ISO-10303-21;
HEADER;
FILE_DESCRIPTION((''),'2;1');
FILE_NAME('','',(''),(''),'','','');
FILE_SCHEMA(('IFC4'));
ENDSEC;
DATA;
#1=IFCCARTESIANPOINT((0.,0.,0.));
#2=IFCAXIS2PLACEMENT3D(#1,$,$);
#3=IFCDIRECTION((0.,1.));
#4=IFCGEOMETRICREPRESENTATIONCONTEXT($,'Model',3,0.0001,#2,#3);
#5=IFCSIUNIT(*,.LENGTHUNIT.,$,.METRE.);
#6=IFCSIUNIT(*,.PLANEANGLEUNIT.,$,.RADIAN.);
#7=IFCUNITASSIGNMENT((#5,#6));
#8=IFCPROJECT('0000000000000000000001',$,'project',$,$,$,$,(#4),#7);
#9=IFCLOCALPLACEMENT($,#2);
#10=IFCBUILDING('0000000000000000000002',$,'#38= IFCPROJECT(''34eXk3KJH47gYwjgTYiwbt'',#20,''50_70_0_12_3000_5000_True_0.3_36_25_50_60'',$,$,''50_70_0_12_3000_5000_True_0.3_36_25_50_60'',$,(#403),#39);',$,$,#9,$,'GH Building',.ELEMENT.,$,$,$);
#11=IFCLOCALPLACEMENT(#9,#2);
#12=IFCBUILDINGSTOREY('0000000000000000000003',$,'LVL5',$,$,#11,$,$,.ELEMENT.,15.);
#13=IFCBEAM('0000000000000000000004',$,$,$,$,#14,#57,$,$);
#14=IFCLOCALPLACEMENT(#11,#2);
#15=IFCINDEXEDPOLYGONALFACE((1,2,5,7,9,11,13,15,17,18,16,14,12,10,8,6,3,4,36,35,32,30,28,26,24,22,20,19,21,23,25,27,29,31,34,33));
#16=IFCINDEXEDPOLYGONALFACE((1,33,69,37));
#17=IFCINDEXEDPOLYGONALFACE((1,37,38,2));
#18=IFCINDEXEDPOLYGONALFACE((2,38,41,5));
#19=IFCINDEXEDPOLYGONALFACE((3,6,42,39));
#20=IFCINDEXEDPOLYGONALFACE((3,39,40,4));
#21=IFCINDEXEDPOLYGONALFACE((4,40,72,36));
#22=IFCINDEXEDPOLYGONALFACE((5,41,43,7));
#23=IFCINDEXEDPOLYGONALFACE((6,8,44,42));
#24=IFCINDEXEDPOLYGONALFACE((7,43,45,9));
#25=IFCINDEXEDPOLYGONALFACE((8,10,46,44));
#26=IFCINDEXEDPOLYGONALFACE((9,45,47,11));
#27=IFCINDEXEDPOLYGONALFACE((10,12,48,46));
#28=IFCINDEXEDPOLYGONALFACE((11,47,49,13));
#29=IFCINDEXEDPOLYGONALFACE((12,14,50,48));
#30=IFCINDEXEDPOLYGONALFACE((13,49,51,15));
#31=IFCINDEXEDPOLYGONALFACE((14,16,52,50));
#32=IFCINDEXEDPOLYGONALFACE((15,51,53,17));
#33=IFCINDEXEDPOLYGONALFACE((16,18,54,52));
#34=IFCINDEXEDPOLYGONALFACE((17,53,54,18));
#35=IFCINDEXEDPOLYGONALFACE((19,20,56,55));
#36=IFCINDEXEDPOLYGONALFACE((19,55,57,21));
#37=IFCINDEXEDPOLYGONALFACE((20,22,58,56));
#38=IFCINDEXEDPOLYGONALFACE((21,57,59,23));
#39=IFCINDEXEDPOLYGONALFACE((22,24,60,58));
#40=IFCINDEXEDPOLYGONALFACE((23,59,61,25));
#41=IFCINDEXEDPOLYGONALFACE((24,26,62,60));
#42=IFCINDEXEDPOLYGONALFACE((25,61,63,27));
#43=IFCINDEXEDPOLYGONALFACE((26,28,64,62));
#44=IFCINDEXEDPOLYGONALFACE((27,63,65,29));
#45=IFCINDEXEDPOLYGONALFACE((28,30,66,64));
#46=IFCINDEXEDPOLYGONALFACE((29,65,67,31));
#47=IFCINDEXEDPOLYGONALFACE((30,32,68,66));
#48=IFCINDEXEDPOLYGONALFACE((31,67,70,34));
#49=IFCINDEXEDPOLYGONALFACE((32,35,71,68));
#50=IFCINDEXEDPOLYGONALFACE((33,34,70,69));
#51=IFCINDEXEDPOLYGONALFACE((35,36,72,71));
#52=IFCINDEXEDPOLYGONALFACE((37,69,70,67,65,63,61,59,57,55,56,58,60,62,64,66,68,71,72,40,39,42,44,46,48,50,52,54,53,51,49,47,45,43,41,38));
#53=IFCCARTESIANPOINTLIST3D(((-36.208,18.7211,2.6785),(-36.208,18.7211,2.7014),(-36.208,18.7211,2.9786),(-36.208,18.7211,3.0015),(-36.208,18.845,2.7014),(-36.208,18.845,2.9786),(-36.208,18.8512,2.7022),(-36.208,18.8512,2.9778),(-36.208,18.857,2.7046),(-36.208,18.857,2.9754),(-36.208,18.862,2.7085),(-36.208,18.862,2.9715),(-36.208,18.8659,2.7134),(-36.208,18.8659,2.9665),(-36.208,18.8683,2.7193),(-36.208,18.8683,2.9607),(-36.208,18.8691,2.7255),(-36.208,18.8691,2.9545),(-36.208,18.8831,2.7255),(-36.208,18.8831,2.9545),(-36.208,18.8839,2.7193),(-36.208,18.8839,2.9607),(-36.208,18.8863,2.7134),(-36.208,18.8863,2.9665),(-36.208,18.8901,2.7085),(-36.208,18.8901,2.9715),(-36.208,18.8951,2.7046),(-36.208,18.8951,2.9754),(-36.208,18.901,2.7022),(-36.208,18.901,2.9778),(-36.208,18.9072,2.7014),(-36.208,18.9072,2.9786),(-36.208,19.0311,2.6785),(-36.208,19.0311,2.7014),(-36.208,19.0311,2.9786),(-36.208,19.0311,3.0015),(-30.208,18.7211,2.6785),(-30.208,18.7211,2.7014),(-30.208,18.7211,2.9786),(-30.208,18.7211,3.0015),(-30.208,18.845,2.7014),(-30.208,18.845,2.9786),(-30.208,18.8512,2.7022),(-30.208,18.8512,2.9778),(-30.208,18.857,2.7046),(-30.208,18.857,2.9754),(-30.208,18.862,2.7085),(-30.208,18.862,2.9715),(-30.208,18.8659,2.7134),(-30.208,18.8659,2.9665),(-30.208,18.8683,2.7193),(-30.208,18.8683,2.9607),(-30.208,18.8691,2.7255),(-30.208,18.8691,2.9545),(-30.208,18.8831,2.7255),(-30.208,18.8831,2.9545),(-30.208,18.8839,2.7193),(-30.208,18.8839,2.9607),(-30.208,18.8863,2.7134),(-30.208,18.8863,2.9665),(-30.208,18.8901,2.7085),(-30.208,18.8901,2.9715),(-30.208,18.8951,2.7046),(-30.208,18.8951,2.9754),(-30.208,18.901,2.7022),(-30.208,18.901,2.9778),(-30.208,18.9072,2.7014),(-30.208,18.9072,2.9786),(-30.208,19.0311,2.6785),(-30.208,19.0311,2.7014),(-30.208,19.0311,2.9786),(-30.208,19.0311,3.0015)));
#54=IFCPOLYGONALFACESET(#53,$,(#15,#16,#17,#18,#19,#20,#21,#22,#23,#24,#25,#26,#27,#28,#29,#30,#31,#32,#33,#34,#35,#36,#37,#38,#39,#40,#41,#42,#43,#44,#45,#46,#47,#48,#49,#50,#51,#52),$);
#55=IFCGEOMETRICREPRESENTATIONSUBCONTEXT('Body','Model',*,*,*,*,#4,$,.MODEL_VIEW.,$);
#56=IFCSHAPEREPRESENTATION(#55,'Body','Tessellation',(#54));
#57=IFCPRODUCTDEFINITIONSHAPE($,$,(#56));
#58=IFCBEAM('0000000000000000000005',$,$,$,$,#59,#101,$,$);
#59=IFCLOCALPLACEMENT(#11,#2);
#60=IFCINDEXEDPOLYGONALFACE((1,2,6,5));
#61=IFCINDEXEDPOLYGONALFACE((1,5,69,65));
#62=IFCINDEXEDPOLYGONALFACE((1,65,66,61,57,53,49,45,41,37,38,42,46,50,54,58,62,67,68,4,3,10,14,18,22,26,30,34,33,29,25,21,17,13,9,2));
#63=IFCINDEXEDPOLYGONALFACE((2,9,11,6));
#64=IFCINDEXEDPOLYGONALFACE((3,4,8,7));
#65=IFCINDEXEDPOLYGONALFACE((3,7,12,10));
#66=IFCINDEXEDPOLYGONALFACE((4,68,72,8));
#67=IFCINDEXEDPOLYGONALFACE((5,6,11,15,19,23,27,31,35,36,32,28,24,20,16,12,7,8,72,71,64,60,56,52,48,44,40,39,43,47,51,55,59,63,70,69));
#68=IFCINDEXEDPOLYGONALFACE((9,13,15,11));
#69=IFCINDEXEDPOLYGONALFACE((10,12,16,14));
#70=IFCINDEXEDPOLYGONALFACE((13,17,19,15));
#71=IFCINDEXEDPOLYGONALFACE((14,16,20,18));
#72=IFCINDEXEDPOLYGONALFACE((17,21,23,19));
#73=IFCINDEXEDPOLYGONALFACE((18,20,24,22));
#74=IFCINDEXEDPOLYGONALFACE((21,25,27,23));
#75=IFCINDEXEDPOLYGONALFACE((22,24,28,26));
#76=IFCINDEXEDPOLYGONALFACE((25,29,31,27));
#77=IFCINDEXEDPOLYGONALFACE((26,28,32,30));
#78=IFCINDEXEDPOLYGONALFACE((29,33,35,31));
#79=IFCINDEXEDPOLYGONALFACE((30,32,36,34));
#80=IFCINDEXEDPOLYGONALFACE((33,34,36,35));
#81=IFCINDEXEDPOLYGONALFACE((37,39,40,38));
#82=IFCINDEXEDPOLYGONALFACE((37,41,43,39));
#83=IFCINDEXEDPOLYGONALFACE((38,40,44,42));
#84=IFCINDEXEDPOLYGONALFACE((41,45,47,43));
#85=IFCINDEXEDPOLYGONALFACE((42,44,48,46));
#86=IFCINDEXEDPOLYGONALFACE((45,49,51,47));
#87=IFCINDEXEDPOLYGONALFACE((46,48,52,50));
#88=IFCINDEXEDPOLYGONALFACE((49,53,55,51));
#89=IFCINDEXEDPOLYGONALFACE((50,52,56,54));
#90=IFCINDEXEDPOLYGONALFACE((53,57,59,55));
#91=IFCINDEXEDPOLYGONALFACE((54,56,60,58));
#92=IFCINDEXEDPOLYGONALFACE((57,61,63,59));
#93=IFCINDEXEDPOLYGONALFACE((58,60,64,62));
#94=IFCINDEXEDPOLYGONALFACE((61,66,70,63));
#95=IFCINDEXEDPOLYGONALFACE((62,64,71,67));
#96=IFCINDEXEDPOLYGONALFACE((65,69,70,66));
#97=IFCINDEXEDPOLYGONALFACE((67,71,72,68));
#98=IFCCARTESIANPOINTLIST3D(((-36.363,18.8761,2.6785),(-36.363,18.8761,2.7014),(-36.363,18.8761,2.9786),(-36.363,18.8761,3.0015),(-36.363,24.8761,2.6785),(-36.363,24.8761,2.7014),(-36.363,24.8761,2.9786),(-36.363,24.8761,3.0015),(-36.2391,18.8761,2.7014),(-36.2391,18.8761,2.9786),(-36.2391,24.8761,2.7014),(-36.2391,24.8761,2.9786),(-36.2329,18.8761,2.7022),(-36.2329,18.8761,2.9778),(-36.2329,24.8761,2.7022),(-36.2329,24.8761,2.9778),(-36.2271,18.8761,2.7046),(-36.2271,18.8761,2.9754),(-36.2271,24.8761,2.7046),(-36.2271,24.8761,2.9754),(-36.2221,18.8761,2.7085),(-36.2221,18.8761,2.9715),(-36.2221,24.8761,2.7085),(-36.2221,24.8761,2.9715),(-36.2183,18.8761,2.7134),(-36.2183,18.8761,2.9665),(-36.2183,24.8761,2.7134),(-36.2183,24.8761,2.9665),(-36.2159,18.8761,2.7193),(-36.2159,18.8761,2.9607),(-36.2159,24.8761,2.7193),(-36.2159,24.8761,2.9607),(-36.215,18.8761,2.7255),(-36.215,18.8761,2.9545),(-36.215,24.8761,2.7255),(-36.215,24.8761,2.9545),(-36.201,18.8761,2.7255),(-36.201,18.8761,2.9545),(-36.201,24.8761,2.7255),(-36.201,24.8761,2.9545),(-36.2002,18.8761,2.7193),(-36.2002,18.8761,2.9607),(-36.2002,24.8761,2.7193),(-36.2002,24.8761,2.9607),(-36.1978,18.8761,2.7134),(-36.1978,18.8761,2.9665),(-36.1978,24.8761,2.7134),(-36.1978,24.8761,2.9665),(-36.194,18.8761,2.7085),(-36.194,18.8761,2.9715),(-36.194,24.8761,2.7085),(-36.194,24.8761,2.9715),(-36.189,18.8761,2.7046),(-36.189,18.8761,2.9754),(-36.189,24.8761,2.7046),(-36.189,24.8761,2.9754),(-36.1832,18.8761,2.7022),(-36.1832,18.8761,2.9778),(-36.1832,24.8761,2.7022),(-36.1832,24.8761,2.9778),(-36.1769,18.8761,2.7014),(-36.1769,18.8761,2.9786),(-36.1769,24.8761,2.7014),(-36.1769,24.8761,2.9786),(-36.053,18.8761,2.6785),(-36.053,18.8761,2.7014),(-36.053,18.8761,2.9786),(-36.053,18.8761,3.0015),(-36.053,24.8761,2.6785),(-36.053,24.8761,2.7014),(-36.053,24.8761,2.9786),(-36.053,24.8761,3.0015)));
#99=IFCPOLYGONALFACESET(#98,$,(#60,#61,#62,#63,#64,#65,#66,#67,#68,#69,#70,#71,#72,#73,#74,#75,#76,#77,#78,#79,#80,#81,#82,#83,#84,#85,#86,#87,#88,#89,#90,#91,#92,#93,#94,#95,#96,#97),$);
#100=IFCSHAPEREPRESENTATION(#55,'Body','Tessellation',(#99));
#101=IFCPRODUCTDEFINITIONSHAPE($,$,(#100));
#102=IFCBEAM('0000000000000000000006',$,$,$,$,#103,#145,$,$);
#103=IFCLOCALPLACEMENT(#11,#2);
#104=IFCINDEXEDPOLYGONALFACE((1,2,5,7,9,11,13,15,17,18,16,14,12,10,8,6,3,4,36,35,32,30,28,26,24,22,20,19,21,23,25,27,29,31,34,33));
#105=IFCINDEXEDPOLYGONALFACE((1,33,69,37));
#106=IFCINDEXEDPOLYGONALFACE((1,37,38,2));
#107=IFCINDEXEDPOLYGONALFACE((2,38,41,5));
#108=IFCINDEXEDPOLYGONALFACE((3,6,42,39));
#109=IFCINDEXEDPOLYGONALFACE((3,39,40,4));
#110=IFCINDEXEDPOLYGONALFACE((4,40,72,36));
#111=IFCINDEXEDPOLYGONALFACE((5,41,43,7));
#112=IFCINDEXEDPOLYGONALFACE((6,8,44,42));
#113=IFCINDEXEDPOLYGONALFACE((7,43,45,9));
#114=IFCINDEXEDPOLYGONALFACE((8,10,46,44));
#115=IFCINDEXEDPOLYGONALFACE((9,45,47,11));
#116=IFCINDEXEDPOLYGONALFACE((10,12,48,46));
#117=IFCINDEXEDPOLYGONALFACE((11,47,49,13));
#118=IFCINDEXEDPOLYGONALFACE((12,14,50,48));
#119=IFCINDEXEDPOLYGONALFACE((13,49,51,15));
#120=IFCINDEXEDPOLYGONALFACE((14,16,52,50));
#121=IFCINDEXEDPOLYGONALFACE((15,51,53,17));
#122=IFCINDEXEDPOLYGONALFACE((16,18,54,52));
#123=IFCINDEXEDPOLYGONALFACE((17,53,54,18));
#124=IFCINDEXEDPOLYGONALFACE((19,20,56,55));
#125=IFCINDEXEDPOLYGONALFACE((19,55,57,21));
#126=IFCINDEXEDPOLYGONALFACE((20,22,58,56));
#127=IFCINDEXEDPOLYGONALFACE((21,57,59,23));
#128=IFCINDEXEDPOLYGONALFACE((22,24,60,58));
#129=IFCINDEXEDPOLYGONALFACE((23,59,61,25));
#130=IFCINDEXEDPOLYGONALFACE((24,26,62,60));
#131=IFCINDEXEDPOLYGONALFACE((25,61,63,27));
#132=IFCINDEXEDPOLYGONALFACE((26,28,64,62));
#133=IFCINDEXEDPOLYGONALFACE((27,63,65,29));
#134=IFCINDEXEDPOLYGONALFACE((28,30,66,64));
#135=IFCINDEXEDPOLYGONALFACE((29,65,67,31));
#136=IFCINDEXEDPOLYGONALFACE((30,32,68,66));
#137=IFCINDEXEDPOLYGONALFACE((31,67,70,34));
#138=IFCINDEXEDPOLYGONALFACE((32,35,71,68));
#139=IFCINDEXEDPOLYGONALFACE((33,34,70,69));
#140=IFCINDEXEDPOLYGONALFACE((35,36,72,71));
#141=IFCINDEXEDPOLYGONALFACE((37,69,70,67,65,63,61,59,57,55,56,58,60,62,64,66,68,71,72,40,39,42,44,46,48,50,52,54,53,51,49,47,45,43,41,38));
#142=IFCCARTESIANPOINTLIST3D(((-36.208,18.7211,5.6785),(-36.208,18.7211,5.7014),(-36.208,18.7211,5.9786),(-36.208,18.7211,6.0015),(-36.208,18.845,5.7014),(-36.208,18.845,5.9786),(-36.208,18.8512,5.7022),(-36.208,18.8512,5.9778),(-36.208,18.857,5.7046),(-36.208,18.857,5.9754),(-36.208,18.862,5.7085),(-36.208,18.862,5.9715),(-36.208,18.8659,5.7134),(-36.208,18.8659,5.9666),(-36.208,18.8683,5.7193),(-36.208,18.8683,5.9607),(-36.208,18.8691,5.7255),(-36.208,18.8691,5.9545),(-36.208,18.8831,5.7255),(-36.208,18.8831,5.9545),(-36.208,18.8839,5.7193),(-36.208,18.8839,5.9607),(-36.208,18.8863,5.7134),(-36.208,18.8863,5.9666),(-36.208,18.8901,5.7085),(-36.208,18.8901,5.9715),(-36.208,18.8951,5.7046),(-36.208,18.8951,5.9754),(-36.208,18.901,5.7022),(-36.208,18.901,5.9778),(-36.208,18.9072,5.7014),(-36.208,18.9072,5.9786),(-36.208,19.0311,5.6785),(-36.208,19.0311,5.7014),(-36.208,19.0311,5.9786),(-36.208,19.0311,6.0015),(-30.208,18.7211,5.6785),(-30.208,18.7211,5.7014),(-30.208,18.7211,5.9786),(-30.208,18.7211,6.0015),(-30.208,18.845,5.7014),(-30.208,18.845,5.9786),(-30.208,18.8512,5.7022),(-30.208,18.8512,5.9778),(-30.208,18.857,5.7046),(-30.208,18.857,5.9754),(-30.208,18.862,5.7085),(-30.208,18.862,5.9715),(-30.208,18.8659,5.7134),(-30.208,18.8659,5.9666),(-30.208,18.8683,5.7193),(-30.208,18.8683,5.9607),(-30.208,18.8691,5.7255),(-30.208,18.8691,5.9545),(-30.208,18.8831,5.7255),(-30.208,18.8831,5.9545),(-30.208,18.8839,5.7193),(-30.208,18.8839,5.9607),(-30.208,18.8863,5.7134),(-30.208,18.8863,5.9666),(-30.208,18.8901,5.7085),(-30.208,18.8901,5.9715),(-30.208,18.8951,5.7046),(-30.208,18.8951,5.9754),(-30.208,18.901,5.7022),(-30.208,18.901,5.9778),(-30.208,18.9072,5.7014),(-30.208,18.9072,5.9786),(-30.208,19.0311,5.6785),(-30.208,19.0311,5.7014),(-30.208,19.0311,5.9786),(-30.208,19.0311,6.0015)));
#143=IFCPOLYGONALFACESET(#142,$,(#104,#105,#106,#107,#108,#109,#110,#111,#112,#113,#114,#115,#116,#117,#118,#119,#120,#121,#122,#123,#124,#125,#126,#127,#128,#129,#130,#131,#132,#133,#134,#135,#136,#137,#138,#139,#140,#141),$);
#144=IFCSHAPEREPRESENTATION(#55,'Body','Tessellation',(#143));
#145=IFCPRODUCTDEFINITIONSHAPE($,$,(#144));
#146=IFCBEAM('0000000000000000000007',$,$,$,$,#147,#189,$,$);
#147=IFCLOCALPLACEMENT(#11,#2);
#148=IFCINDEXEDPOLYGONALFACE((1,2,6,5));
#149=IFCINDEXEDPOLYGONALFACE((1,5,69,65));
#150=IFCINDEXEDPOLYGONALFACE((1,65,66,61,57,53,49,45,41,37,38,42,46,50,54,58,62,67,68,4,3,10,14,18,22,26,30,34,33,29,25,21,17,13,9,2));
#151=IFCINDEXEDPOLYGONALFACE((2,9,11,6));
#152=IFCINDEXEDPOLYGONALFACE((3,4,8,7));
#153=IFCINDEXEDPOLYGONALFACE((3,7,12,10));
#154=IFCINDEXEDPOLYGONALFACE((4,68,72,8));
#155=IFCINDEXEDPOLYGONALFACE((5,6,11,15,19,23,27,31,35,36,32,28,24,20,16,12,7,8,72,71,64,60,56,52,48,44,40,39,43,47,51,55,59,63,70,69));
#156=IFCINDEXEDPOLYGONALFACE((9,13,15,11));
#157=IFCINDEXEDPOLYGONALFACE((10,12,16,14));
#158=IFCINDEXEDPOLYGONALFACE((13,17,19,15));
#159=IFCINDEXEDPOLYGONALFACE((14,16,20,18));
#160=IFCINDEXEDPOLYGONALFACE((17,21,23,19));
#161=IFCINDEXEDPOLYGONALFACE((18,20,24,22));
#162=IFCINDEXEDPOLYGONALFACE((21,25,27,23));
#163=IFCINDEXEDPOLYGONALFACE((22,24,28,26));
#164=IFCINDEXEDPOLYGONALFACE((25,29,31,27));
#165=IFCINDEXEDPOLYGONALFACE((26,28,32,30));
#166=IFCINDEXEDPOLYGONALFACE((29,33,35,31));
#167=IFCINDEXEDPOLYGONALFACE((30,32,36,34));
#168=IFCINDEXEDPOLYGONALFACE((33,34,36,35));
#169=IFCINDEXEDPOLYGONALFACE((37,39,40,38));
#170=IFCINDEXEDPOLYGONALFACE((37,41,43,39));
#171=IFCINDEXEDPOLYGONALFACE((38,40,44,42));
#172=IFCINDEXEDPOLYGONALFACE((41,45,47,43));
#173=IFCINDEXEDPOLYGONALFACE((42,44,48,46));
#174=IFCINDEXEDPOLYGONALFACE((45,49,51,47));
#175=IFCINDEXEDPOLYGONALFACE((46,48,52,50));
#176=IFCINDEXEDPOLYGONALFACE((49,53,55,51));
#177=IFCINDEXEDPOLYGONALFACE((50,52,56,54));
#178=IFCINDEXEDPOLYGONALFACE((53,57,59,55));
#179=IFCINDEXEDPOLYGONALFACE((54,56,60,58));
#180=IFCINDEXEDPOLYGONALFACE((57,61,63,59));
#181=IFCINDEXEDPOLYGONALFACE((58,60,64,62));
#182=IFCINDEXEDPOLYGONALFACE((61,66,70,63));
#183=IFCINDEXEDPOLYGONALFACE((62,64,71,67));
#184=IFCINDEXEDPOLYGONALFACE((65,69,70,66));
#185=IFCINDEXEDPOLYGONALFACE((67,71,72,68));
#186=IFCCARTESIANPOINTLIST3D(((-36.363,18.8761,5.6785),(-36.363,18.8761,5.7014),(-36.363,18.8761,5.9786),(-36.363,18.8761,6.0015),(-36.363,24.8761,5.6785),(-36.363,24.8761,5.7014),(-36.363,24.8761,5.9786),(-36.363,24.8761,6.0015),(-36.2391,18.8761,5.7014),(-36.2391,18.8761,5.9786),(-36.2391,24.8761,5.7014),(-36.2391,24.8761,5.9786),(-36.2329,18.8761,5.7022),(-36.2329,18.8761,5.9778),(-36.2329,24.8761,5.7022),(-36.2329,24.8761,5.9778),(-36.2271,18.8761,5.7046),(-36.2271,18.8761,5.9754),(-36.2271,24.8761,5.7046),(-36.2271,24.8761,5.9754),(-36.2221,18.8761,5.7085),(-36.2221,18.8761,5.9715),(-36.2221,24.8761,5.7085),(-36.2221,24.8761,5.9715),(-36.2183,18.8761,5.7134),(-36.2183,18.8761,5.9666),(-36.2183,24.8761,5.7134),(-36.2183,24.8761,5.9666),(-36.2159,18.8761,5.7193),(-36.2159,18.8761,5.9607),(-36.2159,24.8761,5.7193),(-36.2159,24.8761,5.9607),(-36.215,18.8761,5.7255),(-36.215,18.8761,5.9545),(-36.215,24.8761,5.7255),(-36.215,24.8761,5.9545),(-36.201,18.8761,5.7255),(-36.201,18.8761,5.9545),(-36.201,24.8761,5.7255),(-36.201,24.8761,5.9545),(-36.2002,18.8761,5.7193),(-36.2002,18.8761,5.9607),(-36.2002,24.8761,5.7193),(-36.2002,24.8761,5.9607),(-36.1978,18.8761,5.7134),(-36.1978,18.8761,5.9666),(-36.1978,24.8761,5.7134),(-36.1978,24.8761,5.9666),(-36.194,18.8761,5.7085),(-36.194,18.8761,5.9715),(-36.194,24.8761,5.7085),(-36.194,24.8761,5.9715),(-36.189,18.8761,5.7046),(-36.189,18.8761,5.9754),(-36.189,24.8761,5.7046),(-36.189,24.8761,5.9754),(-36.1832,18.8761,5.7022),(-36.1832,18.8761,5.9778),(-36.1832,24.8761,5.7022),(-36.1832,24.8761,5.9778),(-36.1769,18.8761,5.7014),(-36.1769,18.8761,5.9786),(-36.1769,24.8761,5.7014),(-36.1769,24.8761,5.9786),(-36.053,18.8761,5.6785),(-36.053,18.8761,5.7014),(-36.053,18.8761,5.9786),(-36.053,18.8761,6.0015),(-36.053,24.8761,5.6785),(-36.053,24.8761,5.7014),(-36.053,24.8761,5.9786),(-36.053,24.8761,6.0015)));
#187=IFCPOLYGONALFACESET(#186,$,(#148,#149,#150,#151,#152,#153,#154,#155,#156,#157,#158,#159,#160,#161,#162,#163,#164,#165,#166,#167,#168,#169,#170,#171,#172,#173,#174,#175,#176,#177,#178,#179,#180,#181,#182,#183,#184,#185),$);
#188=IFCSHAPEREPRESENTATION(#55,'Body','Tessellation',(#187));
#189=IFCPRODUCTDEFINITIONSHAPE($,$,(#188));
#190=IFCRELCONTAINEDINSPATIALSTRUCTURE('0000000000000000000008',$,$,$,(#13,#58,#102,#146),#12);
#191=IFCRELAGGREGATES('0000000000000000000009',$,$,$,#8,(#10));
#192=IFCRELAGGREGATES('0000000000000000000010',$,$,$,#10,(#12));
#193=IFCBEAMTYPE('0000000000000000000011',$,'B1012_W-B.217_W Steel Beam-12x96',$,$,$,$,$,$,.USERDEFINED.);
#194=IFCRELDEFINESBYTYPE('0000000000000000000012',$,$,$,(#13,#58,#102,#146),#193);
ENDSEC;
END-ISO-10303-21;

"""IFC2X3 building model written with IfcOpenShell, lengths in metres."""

from ifc_helpers import new_model, si_unit, direction, frame, origin, origin_2d, place, context, subcontext, project, spatial, i_section, extrude, type_object, element, save


model = new_model("IFC2X3")

# Units and contexts
model_context = context("Model", 3, precision=0.0001, world=origin(), true_north=direction((0.0, 1.0)))
body_context = subcontext(model_context, "Body", "Model", "MODEL_VIEW")
ifc_project = project(units=[si_unit("LENGTHUNIT", "METRE"), si_unit("PLANEANGLEUNIT", "RADIAN")], contexts=[model_context])

# Building, storey
building_placement = place(None, origin())
building = spatial("IfcBuilding", under=ifc_project, at=building_placement, Name="#38= IFCPROJECT('34eXk3KJH47gYwjgTYiwbt',#20,'50_70_0_12_3000_5000_True_0.3_36_25_50_60',$,$,'50_70_0_12_3000_5000_True_0.3_36_25_50_60',$,(#403),#39);", LongName="GH Building", CompositionType="ELEMENT")
storey_placement = place(building_placement, origin())
storey = spatial("IfcBuildingStorey", under=building, at=storey_placement, Name="LVL5", CompositionType="ELEMENT", Elevation=15.0)

# Beams
beam_type = type_object("IfcBeamType", Name="B1012_W-B.217_W Steel Beam-12x96", PredefinedType="USERDEFINED")
for number, where, z_axis, x_axis in (
    (1, (-36.208, 18.8761, 2.84), (1.0, 0.0, 0.0), (0.0, 1.0, 0.0)),
    (2, (-36.208, 18.8761, 2.84), (0.0, 1.0, 0.0), (-1.0, 0.0, 0.0)),
    (3, (-36.208, 18.8761, 5.84), (1.0, 0.0, 0.0), (0.0, 1.0, 0.0)),
    (4, (-36.208, 18.8761, 5.84), (0.0, 1.0, 0.0), (-1.0, 0.0, 0.0)),
):
    element("IfcBeam", number, at=place(storey_placement, frame(where, z_axis=z_axis, x_axis=x_axis)), inside=storey, type_object=beam_type, context=body_context, shape_type="SweptSolid", body=[
        extrude(i_section(OverallWidth=0.31, OverallDepth=0.323, WebThickness=0.014, FlangeThickness=0.0229, FilletRadius=0.0241, at=origin_2d()), origin(), (0.0, 0.0, 1.0), 6.0),
    ])

save(model, "model.ifc")
